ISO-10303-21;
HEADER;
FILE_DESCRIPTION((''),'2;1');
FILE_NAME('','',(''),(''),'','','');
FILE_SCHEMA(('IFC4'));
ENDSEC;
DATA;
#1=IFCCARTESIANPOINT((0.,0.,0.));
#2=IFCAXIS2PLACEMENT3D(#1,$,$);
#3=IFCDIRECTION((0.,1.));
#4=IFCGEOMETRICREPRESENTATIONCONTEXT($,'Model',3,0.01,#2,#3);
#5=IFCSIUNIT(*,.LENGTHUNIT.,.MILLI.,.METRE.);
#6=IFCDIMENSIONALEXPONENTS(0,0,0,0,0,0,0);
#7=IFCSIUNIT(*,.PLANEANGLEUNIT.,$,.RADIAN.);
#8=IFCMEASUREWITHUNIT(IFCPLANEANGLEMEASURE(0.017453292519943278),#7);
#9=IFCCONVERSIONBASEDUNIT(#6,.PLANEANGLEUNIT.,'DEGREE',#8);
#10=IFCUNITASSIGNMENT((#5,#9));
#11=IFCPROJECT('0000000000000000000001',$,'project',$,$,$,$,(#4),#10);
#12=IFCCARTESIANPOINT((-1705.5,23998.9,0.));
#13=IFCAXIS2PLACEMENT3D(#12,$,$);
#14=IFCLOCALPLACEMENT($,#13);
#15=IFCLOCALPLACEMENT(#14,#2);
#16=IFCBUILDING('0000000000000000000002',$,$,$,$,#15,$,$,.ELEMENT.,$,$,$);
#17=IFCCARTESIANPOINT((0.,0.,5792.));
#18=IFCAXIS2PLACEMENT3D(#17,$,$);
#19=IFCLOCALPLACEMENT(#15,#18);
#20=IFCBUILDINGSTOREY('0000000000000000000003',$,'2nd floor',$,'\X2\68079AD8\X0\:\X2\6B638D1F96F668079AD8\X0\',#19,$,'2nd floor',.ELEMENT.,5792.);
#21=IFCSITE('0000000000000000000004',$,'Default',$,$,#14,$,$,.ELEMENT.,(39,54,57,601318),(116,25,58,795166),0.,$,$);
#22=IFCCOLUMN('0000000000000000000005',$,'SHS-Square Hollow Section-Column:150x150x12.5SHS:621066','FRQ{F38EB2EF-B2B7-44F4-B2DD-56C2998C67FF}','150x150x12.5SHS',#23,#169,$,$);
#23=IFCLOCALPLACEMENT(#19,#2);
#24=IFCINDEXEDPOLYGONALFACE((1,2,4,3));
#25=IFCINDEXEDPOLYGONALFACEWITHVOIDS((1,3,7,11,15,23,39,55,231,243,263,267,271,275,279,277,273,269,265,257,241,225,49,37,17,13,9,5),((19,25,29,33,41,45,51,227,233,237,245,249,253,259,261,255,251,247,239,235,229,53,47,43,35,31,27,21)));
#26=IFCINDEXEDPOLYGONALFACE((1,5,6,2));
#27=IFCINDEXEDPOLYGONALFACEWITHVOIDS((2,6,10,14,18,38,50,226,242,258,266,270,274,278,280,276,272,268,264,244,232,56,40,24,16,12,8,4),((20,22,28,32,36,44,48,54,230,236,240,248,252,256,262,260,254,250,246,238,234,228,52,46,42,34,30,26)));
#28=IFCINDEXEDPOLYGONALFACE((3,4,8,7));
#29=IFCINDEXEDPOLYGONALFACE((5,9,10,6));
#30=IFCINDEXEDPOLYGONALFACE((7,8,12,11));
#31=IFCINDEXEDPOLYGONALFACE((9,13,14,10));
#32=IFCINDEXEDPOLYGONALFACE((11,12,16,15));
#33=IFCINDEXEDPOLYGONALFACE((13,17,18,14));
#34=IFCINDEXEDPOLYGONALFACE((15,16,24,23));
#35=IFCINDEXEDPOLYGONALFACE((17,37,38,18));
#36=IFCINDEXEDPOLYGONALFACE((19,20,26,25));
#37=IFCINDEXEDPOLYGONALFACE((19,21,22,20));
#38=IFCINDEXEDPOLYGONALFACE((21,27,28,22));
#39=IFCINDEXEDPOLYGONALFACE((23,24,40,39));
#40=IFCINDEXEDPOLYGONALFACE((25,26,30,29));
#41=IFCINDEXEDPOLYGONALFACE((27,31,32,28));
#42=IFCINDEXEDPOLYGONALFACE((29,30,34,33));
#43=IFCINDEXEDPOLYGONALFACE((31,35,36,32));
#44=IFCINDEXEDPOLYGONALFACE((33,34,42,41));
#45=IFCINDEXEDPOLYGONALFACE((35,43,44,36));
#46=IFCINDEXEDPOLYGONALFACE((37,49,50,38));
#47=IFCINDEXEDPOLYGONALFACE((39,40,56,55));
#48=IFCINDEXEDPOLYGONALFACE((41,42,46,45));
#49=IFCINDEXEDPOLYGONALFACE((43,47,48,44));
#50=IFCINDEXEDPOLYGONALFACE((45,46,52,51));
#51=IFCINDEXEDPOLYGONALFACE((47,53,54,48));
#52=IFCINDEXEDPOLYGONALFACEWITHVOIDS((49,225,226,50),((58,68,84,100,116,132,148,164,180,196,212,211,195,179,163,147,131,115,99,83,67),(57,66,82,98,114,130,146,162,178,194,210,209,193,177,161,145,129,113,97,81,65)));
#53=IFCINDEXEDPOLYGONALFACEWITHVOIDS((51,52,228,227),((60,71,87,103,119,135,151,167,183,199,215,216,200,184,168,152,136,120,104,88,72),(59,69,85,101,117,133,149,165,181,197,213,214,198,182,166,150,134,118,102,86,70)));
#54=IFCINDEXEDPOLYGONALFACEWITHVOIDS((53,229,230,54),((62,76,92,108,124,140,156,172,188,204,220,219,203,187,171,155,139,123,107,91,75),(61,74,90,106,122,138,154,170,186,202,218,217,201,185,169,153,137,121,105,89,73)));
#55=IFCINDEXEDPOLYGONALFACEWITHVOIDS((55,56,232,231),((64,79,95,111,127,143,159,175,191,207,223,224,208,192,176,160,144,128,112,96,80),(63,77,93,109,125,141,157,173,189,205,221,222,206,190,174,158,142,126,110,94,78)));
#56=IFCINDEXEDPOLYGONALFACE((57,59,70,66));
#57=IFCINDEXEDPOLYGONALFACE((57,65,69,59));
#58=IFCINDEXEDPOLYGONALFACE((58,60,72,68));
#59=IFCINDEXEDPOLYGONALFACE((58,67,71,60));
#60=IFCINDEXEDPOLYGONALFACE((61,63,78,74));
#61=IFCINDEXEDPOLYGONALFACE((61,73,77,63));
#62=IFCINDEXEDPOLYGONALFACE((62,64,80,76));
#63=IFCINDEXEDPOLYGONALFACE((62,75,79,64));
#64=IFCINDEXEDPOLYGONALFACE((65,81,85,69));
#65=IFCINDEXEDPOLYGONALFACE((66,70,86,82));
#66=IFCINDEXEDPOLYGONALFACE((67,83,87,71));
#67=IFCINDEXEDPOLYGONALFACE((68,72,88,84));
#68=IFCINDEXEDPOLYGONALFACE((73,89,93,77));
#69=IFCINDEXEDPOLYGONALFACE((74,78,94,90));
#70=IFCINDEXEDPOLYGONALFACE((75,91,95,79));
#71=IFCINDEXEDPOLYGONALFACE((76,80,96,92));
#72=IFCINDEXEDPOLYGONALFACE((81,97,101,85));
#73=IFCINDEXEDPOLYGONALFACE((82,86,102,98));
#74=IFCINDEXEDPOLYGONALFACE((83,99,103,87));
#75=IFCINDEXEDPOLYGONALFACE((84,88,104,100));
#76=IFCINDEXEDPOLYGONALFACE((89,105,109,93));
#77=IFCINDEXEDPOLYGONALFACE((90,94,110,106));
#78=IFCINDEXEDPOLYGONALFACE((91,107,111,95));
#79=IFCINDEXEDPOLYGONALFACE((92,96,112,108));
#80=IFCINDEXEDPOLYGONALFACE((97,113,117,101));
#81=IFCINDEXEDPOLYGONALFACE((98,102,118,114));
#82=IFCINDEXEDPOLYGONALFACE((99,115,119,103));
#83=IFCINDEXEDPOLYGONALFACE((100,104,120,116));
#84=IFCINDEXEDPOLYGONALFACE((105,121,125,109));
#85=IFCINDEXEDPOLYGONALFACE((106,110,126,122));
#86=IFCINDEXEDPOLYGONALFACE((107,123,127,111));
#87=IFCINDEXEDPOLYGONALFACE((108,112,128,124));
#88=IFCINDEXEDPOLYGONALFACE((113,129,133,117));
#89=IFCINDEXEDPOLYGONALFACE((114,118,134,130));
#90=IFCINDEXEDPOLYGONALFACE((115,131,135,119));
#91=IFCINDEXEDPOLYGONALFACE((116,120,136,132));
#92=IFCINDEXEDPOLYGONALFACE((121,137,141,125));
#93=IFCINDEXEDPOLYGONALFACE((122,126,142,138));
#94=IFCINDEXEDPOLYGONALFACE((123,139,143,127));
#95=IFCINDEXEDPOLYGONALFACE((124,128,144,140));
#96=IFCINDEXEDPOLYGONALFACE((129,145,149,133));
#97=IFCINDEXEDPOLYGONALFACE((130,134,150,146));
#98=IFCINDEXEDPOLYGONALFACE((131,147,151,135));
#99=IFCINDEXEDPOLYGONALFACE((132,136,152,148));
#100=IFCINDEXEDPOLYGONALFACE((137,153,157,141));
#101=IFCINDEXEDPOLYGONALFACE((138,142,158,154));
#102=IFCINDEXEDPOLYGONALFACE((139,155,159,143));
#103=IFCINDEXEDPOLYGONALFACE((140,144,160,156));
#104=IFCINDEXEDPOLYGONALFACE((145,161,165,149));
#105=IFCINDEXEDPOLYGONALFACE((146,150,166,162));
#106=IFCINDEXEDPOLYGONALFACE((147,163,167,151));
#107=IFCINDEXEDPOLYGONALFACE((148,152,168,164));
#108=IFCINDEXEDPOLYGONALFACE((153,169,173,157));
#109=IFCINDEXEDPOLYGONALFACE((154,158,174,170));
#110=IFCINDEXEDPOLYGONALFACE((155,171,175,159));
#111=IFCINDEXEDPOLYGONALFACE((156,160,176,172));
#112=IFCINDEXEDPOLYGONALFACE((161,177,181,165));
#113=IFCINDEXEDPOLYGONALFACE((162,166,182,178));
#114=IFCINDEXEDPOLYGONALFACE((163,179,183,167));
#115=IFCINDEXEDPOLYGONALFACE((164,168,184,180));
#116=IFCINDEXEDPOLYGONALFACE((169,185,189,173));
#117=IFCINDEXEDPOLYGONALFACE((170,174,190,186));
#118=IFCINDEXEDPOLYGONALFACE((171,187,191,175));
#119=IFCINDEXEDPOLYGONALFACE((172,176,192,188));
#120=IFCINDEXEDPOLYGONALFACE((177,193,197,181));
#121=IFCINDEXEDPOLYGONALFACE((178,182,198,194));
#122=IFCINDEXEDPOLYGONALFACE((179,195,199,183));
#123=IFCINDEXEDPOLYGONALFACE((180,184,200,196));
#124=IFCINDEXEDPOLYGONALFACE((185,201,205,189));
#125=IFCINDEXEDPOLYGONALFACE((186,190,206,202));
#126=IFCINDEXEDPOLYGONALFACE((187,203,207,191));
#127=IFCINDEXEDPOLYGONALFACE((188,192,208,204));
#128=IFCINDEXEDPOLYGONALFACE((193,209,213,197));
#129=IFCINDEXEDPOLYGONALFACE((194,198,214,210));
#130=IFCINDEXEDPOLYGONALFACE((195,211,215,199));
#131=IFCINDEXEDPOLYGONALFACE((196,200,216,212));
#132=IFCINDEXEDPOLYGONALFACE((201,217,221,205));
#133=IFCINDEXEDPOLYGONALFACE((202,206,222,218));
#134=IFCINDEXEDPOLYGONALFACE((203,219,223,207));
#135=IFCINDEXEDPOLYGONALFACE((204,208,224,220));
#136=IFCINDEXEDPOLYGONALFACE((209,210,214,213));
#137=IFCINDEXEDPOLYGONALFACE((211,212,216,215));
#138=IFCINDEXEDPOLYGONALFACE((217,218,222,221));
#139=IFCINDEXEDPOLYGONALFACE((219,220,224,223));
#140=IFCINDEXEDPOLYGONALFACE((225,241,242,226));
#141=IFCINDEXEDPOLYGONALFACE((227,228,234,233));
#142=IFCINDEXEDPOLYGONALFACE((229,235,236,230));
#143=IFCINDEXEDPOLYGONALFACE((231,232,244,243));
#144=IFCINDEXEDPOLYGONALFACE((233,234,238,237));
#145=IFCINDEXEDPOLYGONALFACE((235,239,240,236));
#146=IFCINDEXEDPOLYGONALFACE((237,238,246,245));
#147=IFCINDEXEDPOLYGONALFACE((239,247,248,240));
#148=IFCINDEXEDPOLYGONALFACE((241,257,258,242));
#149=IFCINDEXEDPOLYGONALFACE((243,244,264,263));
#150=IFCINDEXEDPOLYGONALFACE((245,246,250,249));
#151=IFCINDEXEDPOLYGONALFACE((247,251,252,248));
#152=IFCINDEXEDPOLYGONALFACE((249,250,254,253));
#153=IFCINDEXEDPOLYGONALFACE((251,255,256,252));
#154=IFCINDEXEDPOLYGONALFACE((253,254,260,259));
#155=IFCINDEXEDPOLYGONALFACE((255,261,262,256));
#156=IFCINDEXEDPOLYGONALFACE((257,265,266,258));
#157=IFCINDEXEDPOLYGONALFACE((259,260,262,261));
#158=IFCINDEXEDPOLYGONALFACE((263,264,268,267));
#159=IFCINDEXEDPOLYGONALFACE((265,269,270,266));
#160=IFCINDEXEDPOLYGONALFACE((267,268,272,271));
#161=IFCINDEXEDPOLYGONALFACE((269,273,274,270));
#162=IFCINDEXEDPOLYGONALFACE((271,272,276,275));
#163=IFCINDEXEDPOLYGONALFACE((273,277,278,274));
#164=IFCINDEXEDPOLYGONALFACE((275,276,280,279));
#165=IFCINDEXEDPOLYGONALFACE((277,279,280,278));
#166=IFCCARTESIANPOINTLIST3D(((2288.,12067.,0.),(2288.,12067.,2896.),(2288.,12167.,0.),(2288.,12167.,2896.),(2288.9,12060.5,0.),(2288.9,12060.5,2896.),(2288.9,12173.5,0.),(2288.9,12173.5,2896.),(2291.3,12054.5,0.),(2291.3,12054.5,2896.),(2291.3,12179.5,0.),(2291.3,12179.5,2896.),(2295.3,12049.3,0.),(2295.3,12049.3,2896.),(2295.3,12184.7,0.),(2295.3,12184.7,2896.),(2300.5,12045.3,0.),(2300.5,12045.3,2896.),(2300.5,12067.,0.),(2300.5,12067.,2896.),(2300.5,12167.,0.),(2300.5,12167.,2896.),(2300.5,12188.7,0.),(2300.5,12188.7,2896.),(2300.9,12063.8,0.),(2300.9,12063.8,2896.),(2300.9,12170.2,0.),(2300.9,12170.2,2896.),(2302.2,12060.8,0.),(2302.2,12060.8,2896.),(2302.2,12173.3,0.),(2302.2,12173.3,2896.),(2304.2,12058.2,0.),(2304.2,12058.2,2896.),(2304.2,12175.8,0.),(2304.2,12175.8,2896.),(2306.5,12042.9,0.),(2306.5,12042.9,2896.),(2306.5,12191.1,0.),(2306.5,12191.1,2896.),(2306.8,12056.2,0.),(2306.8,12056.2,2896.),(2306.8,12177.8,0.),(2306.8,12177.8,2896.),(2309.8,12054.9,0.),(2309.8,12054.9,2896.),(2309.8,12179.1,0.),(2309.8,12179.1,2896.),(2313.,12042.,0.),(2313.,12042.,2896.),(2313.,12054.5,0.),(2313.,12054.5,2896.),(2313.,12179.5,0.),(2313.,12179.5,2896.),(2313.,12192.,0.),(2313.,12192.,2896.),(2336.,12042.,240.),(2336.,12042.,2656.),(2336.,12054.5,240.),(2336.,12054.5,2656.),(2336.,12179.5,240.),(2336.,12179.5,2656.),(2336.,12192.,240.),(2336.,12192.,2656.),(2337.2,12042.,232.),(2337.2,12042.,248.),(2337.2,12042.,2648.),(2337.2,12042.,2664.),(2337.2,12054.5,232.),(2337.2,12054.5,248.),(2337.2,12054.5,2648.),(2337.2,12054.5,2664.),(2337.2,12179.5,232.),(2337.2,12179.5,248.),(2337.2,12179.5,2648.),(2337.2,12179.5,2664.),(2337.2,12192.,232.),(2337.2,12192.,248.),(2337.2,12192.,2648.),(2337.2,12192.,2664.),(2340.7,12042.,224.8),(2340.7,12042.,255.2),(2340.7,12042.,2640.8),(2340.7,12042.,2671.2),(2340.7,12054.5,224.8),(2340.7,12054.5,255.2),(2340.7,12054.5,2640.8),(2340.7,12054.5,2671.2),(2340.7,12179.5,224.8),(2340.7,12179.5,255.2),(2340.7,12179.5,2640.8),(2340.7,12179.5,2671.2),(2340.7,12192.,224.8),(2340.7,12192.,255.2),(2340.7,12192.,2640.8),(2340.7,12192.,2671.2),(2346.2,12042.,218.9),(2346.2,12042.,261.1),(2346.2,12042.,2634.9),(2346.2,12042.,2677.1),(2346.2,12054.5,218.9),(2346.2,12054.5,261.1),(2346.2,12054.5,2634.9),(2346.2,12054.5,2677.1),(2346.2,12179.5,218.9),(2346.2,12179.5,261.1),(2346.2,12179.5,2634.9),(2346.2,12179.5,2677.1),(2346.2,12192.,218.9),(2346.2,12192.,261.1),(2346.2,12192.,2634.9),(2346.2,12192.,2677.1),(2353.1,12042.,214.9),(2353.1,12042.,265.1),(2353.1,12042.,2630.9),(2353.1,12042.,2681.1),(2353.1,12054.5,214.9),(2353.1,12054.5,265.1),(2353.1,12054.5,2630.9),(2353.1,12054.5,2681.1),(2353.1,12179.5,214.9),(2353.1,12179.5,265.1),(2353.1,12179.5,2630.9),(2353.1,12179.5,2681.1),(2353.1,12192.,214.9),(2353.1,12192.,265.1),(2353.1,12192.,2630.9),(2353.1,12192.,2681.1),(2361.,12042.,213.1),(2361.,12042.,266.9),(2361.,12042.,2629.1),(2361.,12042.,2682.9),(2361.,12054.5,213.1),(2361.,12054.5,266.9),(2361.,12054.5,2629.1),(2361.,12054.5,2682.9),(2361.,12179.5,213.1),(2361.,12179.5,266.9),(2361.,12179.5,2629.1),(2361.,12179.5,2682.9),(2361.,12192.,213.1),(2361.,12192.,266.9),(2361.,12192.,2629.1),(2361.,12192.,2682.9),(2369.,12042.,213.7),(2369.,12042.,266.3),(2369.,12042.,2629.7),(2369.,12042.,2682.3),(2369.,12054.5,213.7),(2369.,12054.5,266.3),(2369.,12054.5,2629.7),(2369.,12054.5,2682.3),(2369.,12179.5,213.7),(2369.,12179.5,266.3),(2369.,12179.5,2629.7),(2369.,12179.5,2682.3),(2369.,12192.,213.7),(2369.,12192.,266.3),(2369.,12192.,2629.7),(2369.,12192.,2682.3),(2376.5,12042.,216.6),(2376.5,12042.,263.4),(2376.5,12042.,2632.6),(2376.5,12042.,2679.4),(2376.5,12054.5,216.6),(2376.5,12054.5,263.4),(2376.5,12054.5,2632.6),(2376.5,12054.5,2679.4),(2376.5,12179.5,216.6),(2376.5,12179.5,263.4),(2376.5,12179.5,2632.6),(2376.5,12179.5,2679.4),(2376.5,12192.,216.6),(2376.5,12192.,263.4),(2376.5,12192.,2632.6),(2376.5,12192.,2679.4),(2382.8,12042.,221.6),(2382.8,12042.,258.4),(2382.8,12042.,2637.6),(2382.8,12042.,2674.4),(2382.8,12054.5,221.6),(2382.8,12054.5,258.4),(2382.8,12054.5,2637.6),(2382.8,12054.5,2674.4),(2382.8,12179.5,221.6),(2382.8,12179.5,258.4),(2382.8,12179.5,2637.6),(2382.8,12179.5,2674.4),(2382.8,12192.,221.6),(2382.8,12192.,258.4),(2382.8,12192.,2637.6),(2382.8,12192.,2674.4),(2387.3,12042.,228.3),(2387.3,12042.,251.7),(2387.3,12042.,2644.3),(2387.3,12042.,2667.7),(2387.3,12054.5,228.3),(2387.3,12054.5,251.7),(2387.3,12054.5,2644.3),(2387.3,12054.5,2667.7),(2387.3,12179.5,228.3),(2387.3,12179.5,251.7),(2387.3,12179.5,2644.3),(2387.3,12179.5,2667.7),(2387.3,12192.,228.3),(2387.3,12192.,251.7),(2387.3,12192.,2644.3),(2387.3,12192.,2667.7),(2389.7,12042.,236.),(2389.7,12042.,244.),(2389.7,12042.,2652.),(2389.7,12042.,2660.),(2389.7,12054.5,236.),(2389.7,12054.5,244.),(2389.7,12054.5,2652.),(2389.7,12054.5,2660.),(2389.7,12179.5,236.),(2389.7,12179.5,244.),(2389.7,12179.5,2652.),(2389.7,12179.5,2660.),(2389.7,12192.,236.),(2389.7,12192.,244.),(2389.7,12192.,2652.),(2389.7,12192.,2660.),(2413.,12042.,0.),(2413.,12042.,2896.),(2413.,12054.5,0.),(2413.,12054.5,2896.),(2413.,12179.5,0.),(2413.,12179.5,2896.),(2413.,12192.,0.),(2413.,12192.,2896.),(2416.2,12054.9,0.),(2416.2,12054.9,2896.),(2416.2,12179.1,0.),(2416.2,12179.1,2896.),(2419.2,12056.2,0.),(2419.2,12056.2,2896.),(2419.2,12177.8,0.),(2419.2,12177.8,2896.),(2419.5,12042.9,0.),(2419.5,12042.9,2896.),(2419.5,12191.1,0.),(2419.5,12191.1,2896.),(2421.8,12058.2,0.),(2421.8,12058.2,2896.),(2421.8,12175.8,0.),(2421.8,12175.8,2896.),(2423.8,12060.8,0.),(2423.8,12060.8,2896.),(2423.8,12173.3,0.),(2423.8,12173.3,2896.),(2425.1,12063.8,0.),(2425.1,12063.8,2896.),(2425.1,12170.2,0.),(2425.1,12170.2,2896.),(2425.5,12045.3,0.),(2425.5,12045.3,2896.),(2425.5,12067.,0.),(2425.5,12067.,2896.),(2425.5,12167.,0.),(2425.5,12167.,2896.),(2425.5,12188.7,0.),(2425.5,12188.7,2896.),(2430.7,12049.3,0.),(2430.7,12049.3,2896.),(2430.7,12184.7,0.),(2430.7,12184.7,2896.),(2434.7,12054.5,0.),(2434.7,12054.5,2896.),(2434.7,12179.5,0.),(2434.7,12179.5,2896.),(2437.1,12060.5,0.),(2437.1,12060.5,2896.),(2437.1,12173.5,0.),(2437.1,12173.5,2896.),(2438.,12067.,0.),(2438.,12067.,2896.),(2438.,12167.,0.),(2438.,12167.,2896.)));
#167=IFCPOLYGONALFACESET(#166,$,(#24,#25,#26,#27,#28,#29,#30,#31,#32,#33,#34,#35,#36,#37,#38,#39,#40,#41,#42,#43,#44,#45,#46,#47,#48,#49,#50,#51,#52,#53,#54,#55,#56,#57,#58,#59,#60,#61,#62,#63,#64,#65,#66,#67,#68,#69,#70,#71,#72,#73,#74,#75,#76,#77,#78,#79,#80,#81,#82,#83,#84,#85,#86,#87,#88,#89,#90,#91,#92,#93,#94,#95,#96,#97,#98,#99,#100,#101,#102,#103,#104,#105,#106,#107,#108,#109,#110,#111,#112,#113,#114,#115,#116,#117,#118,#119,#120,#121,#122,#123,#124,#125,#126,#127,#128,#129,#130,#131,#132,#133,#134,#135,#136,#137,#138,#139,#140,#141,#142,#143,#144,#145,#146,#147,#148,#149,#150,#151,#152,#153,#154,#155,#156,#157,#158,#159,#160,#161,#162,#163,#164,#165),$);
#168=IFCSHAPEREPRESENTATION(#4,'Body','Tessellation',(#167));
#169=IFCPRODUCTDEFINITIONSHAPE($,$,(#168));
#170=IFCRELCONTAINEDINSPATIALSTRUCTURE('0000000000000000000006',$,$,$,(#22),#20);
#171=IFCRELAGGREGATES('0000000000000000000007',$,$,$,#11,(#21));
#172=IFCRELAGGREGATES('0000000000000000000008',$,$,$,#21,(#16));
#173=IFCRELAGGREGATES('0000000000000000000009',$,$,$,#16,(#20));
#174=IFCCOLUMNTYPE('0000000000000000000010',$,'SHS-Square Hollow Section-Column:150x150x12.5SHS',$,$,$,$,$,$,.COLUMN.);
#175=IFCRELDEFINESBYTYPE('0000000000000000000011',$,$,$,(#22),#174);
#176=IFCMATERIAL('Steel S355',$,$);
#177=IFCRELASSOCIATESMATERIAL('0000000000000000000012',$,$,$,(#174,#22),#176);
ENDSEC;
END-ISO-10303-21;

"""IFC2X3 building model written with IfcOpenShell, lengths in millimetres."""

from ifc_helpers import new_model, entity, si_unit, converted_unit, direction, frame, frame_2d, origin, origin_2d, place, context, project, spatial, circle_curve, hollow_rectangle, outline, extrude, material, type_object, element, save


model = new_model("IFC2X3")

# Units and contexts
model_context = context("Model", 3, precision=0.01, world=origin(), true_north=direction((0.0, 1.0)))
ifc_project = project(units=[si_unit("LENGTHUNIT", "METRE", prefix="MILLI"), converted_unit("PLANEANGLEUNIT", "DEGREE", entity("IfcPlaneAngleMeasure", 0.017453292519943278), si_unit("PLANEANGLEUNIT", "RADIAN"), dimensions=[0, 0, 0, 0, 0, 0, 0])], contexts=[model_context])

# Site, building, storey
site_placement = place(None, frame((-1705.5, 23998.9, 0.0)))
site = spatial("IfcSite", under=ifc_project, at=site_placement, Name="Default", CompositionType="ELEMENT", RefLatitude=(39, 54, 57, 601318), RefLongitude=(116, 25, 58, 795166), RefElevation=0.0)
building_placement = place(site_placement, origin())
building = spatial("IfcBuilding", under=site, at=building_placement, CompositionType="ELEMENT")
storey_placement = place(building_placement, frame((0.0, 0.0, 5792.0)))
storey = spatial("IfcBuildingStorey", under=building, at=storey_placement, Name="2nd floor", ObjectType="标高:正负零标高", LongName="2nd floor", CompositionType="ELEMENT", Elevation=5792.0)

# Shared definitions
ifc_material_1 = material(Name="Steel S355")

# Column, openings
column_type_1 = type_object("IfcColumnType", Name="SHS-Square Hollow Section-Column:150x150x12.5SHS", PredefinedType="COLUMN", material=ifc_material_1)
column_1_placement = place(storey_placement, frame((2363.0, 12117.0, 2896.0), z_axis=(0.0, 0.0, 1.0), x_axis=(0.0, -1.0, 0.0)))
column_1 = element("IfcColumn", 1, at=column_1_placement, inside=storey, type_object=column_type_1, material=ifc_material_1, Name="SHS-Square Hollow Section-Column:150x150x12.5SHS:621066", Description="FRQ{F38EB2EF-B2B7-44F4-B2DD-56C2998C67FF}", ObjectType="150x150x12.5SHS", context=model_context, shape_type="SweptSolid", body=[
    extrude(hollow_rectangle(XDim=150.0, YDim=150.0, WallThickness=12.5, InnerFilletRadius=12.5, OuterFilletRadius=25.0, at=origin_2d()), origin(), (0.0, 0.0, -1.0), 2896.0),
])
opening_1_placement = place(column_1_placement, frame((175.1, 0.0, 0.0), z_axis=(-1.0, 0.0, 0.0), x_axis=(0.0, -1.0, 0.0)))
element("IfcOpeningElement", 2, at=opening_1_placement, cuts=column_1, ObjectType="Opening", context=model_context, shape_type="SweptSolid", body=[
    extrude(outline(circle_curve(frame_2d((0.0, -240.0), x_axis=(1.0, 0.0)), 27.0)), origin(), (0.0, 0.0, 1.0), 350.2),
])
opening_2_placement = place(column_1_placement, frame((175.1, 0.0, -2896.0), z_axis=(-1.0, 0.0, 0.0), x_axis=(0.0, -1.0, 0.0)))
element("IfcOpeningElement", 3, at=opening_2_placement, cuts=column_1, ObjectType="Opening", context=model_context, shape_type="SweptSolid", body=[
    extrude(outline(circle_curve(frame_2d((0.0, 240.0), x_axis=(1.0, 0.0)), 27.0)), origin(), (0.0, 0.0, 1.0), 350.2),
])

save(model, "model.ifc")
